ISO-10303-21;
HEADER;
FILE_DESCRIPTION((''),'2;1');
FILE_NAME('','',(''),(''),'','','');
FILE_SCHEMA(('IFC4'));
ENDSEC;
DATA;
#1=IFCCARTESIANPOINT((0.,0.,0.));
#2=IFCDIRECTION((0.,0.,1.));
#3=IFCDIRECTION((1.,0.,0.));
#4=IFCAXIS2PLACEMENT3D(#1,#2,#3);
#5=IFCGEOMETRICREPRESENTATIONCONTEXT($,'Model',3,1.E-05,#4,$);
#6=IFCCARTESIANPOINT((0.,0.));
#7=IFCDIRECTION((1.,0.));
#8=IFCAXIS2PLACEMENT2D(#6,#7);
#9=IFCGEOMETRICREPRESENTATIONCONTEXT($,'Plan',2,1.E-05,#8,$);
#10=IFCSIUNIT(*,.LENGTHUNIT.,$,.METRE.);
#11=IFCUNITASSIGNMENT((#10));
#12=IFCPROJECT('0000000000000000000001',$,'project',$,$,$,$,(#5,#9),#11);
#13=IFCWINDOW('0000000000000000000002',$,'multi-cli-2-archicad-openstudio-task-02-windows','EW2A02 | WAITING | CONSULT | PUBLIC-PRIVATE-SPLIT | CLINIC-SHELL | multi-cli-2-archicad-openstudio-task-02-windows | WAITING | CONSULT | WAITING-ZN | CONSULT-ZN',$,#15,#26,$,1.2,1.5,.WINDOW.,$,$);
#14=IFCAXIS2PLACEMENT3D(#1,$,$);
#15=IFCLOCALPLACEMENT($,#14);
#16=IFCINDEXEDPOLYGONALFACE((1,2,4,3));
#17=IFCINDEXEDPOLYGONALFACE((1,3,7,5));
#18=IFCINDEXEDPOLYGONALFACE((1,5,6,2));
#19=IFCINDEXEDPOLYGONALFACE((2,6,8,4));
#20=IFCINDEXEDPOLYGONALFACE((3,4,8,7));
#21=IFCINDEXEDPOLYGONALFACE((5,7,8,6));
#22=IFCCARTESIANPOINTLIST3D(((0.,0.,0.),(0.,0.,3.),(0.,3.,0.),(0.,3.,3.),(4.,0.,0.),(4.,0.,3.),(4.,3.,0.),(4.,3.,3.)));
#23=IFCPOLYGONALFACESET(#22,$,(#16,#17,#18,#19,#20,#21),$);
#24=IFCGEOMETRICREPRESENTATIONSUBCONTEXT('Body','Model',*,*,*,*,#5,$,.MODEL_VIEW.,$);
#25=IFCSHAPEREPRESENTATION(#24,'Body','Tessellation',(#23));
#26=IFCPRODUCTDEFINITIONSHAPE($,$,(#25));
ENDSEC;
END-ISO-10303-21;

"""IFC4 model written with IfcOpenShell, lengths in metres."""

from ifc_helpers import new_model, si_unit, origin_with_axes, origin_2d_with_axis, place, context, subcontext, project, polyline, outline, extrude, element, save


model = new_model("IFC4")

# Units and contexts
model_context = context("Model", 3, precision=1e-05, world=origin_with_axes())
plan_context = context("Plan", 2, precision=1e-05, world=origin_2d_with_axis())
body_context = subcontext(model_context, "Body", "Model", "MODEL_VIEW")
ifc_project = project(units=[si_unit("LENGTHUNIT", "METRE")], contexts=[model_context, plan_context])

# Shared definitions
placement_1 = place(None, origin_with_axes())
placement_2 = place(placement_1, origin_with_axes())

# Window
element("IfcWindow", 1, at=placement_2, Name="multi-cli-2-archicad-openstudio-task-02-windows", Description="EW2A02 | WAITING | CONSULT | PUBLIC-PRIVATE-SPLIT | CLINIC-SHELL | multi-cli-2-archicad-openstudio-task-02-windows | WAITING | CONSULT | WAITING-ZN | CONSULT-ZN", OverallHeight=1.2, OverallWidth=1.5, PredefinedType="WINDOW", context=body_context, shape_type="SweptSolid", body=[
    extrude(outline(polyline([(0.0, 0.0), (4.0, 0.0), (4.0, 3.0), (0.0, 3.0), (0.0, 0.0)])), origin_with_axes(), (0.0, 0.0, 1.0), 3.0),
])

save(model, "model.ifc")
